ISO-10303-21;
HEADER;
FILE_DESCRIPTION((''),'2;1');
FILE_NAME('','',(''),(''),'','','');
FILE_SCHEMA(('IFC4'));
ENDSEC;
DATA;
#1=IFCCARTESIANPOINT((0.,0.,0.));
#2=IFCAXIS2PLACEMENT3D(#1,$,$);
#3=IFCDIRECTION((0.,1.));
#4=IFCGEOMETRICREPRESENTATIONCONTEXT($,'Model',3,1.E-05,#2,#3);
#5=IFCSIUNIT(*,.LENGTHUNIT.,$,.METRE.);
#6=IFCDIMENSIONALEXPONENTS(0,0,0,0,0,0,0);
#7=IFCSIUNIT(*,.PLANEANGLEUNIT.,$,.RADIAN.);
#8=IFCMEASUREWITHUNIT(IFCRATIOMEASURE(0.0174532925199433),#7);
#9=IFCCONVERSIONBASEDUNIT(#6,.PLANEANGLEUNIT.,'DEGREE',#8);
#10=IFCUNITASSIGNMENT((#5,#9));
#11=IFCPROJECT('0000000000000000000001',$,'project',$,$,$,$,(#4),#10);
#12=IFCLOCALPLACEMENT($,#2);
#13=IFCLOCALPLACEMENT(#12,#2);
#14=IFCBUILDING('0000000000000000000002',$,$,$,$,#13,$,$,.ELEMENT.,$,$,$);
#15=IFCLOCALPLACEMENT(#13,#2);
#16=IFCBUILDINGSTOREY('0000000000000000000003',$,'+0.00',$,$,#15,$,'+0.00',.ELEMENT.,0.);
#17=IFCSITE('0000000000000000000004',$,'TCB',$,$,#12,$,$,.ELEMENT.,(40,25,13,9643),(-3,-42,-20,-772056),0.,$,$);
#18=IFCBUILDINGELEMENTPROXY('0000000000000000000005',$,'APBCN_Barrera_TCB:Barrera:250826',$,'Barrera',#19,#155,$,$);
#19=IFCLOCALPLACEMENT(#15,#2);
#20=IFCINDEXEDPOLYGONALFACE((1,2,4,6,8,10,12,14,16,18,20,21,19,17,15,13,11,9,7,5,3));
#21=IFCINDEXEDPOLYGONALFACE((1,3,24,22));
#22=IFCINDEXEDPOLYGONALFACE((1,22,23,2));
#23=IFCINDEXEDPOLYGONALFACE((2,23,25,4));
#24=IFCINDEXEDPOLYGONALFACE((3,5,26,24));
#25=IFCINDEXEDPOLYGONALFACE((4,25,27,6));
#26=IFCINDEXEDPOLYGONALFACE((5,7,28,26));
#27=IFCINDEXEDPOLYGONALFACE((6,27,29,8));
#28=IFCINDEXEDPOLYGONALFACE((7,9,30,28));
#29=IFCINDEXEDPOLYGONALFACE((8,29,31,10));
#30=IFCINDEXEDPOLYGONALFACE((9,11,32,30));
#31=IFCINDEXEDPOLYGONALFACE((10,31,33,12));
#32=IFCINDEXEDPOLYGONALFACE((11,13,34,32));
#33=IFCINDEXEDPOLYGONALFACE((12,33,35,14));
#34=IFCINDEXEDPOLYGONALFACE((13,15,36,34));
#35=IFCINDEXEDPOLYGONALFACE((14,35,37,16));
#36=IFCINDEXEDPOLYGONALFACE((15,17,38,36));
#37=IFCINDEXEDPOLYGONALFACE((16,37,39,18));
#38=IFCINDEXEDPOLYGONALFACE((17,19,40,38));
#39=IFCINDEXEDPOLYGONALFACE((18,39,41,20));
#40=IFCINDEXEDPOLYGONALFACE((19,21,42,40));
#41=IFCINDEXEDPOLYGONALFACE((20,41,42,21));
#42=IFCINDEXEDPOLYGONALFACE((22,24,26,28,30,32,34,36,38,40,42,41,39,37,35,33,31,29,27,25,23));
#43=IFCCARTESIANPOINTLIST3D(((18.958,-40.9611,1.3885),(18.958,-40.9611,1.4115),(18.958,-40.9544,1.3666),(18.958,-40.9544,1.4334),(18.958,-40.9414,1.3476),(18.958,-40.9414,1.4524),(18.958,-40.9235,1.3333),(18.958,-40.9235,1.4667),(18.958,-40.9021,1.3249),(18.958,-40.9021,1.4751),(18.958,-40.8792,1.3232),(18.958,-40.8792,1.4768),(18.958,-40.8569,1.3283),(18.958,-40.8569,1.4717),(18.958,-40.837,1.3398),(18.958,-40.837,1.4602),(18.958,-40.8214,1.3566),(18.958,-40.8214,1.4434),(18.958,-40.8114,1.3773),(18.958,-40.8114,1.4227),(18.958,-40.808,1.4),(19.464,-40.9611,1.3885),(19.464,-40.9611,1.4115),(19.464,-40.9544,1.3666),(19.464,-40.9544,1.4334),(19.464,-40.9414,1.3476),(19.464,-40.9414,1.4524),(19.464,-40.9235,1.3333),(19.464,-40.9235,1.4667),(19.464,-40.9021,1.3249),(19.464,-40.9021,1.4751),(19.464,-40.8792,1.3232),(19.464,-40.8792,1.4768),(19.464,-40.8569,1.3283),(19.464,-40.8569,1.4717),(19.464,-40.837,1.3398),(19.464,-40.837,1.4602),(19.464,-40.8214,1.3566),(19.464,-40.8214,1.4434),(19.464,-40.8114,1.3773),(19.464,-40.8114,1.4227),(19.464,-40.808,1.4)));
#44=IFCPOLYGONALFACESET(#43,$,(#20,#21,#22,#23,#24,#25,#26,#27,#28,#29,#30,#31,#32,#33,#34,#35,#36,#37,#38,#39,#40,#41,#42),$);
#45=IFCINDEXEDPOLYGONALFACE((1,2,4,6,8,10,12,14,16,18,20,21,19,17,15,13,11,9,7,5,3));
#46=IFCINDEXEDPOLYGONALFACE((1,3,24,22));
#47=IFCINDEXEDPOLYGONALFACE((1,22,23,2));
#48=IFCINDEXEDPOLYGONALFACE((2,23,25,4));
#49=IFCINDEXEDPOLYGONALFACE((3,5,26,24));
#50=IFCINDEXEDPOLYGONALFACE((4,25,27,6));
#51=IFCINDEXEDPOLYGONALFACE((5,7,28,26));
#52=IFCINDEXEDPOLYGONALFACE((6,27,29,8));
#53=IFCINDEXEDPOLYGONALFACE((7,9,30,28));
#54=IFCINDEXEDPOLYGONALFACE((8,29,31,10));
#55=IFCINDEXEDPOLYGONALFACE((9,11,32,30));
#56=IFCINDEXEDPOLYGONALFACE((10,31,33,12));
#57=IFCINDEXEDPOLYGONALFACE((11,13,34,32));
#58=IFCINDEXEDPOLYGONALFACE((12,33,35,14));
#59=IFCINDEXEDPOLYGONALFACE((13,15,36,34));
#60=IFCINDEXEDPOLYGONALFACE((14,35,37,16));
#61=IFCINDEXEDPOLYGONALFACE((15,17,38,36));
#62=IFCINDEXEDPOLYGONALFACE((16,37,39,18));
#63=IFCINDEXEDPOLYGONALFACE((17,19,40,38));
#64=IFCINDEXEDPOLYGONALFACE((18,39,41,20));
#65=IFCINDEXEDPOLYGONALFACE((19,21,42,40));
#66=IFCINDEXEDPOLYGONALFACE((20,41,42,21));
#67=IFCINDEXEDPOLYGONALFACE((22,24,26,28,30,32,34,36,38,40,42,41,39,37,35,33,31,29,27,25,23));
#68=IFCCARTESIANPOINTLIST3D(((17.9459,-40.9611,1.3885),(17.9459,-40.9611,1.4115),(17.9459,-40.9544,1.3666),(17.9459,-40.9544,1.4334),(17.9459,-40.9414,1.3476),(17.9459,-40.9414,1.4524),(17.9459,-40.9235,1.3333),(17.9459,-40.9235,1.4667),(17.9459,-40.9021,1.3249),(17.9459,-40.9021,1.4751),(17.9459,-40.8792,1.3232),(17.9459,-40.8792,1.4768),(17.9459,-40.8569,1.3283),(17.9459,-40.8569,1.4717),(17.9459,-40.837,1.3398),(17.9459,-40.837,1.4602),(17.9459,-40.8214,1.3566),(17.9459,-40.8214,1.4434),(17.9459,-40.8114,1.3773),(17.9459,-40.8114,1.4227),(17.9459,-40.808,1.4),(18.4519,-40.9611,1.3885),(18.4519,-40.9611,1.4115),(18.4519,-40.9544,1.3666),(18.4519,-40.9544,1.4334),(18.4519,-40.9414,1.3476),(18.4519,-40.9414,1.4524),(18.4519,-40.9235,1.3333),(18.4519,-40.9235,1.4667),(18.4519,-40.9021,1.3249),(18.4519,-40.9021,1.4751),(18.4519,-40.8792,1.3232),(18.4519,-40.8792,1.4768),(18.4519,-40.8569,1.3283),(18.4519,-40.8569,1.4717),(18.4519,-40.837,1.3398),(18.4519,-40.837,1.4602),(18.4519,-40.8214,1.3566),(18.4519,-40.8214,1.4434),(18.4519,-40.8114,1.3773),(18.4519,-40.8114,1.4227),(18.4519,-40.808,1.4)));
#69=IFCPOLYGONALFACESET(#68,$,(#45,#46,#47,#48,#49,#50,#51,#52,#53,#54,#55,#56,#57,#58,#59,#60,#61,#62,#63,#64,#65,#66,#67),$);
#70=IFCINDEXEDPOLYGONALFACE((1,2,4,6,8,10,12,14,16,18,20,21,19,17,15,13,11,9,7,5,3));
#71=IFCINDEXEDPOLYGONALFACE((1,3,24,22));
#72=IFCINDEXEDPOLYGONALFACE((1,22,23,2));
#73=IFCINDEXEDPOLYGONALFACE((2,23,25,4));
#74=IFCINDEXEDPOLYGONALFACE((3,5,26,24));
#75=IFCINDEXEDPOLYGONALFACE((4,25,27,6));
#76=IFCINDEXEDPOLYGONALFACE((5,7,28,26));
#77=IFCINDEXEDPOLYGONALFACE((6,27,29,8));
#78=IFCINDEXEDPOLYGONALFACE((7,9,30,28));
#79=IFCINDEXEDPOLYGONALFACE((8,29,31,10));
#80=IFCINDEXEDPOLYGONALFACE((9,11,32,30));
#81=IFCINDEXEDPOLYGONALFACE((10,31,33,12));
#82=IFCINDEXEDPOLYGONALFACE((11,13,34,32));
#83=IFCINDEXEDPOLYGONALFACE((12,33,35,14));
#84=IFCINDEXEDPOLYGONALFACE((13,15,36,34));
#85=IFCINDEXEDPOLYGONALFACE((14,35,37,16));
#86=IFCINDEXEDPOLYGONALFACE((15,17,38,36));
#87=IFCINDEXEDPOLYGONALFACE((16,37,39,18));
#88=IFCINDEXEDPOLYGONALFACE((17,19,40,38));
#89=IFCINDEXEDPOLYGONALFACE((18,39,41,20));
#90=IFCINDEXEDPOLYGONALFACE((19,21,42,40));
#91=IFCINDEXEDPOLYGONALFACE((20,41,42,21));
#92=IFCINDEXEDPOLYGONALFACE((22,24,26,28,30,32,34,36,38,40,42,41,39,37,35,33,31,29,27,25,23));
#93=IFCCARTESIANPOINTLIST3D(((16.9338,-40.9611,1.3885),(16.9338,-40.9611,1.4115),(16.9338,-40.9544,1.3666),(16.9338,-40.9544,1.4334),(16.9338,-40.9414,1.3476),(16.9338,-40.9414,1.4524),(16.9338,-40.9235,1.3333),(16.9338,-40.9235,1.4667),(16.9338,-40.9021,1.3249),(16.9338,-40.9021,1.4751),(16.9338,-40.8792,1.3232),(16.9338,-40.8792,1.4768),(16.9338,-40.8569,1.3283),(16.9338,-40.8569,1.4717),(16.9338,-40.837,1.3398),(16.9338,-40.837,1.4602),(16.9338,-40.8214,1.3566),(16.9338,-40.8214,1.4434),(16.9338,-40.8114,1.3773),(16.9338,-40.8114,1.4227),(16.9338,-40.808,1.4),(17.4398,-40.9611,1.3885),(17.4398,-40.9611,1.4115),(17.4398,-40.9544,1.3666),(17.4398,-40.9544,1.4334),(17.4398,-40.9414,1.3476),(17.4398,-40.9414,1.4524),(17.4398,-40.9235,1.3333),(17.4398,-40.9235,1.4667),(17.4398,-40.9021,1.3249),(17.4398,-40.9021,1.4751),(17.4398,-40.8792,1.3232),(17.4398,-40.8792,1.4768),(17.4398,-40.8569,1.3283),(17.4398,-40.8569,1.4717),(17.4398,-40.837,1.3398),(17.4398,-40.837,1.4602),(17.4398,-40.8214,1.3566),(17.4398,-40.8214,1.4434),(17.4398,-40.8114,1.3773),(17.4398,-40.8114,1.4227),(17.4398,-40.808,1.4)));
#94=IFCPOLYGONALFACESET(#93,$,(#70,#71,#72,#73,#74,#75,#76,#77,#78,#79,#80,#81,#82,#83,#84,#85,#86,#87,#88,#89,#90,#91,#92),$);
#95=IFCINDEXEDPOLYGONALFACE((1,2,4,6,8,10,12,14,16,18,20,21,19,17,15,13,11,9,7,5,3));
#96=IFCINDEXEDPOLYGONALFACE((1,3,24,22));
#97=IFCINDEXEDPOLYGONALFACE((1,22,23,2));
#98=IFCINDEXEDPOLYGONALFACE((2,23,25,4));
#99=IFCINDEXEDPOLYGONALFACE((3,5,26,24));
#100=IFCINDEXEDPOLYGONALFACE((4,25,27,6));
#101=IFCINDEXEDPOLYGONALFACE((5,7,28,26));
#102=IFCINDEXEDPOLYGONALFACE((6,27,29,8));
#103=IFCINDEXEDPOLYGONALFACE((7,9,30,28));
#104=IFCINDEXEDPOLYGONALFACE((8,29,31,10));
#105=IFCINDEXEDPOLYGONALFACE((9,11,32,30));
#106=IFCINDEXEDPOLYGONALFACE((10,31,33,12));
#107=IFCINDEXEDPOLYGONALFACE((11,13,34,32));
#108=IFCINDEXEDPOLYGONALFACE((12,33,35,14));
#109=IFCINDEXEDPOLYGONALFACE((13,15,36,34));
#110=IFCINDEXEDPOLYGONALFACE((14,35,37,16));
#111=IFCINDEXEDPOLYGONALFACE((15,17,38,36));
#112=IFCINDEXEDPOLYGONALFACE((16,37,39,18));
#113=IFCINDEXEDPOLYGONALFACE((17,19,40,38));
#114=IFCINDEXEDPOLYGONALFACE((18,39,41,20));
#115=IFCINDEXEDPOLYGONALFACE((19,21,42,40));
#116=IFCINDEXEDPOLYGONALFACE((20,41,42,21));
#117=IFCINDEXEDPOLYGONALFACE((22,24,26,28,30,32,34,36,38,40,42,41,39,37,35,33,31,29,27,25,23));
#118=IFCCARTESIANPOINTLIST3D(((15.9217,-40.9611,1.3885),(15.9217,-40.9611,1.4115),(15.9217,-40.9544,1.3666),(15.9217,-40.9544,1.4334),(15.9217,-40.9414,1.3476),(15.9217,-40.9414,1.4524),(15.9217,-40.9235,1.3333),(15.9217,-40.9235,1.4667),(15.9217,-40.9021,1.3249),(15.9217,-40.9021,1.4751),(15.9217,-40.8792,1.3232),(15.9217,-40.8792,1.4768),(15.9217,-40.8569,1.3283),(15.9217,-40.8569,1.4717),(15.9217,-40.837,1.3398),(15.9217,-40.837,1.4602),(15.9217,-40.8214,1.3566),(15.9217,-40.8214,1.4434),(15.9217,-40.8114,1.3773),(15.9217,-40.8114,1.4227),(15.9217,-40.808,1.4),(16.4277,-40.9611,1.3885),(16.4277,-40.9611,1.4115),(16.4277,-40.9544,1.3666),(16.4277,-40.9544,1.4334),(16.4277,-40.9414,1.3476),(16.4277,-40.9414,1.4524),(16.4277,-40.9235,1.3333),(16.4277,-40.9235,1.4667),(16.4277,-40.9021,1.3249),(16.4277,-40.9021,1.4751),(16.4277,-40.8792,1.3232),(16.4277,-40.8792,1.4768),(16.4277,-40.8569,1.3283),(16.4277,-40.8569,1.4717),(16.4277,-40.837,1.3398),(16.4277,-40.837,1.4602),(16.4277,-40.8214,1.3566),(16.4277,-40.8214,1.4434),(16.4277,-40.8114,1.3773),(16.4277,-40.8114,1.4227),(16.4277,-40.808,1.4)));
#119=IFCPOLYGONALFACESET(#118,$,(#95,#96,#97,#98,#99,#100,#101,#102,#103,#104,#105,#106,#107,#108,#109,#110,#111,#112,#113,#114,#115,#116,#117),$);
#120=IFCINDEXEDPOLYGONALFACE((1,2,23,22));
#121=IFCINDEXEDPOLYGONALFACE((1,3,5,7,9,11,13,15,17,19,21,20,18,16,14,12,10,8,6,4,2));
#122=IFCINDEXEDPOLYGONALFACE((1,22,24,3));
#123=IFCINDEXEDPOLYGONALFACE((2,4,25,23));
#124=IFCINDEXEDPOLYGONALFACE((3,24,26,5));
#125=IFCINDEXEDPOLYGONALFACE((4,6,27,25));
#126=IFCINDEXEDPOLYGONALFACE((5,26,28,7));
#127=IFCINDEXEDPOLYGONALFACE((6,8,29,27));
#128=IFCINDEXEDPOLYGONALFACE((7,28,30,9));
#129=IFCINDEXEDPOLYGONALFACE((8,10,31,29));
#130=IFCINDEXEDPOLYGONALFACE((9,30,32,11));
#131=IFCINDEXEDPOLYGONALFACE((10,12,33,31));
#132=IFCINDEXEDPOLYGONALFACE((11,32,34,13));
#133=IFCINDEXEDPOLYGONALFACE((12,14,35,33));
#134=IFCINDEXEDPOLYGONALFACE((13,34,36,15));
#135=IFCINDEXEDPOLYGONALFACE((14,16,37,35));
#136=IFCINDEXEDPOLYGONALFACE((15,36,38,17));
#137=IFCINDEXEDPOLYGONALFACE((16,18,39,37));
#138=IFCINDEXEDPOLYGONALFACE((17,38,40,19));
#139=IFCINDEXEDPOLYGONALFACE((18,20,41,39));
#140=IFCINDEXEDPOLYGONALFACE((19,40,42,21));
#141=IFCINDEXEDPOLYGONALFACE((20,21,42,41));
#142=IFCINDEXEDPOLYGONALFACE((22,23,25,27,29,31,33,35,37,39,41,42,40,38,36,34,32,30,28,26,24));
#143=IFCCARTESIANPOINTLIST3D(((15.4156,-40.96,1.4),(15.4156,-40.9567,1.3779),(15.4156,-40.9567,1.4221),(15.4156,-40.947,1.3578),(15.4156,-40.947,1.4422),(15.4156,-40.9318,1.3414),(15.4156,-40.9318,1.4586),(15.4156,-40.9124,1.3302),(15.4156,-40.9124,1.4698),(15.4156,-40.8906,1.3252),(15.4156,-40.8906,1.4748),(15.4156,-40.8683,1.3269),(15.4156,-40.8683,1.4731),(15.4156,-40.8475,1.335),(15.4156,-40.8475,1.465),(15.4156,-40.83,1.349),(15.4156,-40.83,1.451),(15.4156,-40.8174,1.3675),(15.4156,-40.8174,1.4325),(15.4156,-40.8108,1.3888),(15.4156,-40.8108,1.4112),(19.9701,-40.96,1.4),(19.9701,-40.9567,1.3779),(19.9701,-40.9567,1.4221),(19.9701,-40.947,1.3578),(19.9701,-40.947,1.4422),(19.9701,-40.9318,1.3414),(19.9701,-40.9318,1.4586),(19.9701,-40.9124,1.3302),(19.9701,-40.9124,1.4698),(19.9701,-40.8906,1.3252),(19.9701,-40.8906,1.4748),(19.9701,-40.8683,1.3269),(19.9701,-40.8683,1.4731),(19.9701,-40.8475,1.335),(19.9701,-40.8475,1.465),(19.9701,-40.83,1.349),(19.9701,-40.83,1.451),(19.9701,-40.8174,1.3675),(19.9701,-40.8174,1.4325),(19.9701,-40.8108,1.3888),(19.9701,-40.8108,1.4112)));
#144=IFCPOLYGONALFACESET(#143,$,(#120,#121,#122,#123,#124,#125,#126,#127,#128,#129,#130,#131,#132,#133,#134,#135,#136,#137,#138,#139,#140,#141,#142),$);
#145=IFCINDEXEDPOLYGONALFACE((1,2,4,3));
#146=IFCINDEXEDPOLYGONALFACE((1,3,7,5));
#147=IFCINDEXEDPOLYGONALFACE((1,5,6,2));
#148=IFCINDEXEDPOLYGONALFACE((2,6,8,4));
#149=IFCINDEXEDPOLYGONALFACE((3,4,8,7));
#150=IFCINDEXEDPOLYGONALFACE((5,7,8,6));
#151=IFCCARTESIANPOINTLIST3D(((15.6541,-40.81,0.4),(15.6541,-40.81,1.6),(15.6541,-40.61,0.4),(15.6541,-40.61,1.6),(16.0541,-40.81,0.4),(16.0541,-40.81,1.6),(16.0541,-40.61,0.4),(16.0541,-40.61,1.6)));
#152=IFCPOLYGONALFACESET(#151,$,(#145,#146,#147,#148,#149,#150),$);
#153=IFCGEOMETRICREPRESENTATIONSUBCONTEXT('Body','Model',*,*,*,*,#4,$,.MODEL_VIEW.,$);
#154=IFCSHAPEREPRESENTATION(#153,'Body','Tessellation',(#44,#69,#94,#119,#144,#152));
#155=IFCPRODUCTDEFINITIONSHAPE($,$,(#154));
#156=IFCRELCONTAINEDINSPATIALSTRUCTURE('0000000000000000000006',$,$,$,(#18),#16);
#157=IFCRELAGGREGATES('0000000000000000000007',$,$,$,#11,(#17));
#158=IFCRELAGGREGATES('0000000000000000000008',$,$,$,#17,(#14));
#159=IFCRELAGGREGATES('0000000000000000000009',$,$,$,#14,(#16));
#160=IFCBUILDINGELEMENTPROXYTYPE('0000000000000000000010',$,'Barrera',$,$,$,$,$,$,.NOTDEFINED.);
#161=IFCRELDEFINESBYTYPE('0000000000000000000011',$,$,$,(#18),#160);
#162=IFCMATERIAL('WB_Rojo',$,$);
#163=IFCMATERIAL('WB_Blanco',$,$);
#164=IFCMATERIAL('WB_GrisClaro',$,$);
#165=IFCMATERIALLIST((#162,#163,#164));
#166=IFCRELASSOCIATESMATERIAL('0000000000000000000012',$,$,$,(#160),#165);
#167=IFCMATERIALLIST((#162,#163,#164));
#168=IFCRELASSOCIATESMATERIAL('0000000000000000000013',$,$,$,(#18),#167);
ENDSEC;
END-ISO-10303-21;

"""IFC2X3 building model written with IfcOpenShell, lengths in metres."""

from ifc_helpers import new_model, entity, si_unit, converted_unit, direction, frame, frame_2d, origin, place, context, subcontext, project, spatial, rectangle, circle, extrude, source, transform, mapped, material, material_list, type_object, type_shapes, element, save


model = new_model("IFC2X3")

# Units and contexts
model_context = context("Model", 3, precision=1e-05, world=origin(), true_north=direction((0.0, 1.0)))
body_context = subcontext(model_context, "Body", "Model", "MODEL_VIEW")
ifc_project = project(units=[si_unit("LENGTHUNIT", "METRE"), converted_unit("PLANEANGLEUNIT", "DEGREE", entity("IfcRatioMeasure", 0.0174532925199433), si_unit("PLANEANGLEUNIT", "RADIAN"), dimensions=[0, 0, 0, 0, 0, 0, 0])], contexts=[model_context])

# Site, building, storey
site_placement = place(None, origin())
site = spatial("IfcSite", under=ifc_project, at=site_placement, Name="TCB", CompositionType="ELEMENT", RefLatitude=(40, 25, 13, 9643), RefLongitude=(-3, -42, -20, -772056), RefElevation=0.0)
building_placement = place(site_placement, origin())
building = spatial("IfcBuilding", under=site, at=building_placement, CompositionType="ELEMENT")
storey_placement = place(building_placement, origin())
storey = spatial("IfcBuildingStorey", under=building, at=storey_placement, Name="+0.00", LongName="+0.00", CompositionType="ELEMENT", Elevation=0.0)

# Shared definitions
ifc_material_1 = material(Name="WB_Blanco")

# Shared definitions
ifc_material_2 = material(Name="WB_GrisClaro")

# Building element proxy
ifc_material_3 = material(Name="WB_Rojo")
ifc_material_list_1 = material_list([ifc_material_3, ifc_material_1, ifc_material_2])
building_element_proxy_type_1 = type_object("IfcBuildingElementProxyType", Name="Barrera", PredefinedType="NOTDEFINED", material=ifc_material_list_1)
shared_shape_1 = source(origin(), body_context, "Body", "SweptSolid", [
    extrude(circle(Radius=0.077, at=frame_2d((0.0, 0.0), x_axis=(1.0, 0.0))), frame((2.8039, -0.175, 1.0), z_axis=(1.0, 0.0, 0.0), x_axis=(0.0, 1.0, 0.0)), (0.0, 0.0, 1.0), 0.506),
    extrude(circle(Radius=0.077, at=frame_2d((0.0, 0.0), x_axis=(1.0, 0.0))), frame((1.7918, -0.175, 1.0), z_axis=(1.0, 0.0, 0.0), x_axis=(0.0, 1.0, 0.0)), (0.0, 0.0, 1.0), 0.506),
    extrude(circle(Radius=0.077, at=frame_2d((0.0, 0.0), x_axis=(1.0, 0.0))), frame((0.7797, -0.175, 1.0), z_axis=(1.0, 0.0, 0.0), x_axis=(0.0, 1.0, 0.0)), (0.0, 0.0, 1.0), 0.506),
    extrude(circle(Radius=0.077, at=frame_2d((0.0, 0.0), x_axis=(1.0, 0.0))), frame((-0.2324, -0.175, 1.0), z_axis=(1.0, 0.0, 0.0), x_axis=(0.0, 1.0, 0.0)), (0.0, 0.0, 1.0), 0.506),
    extrude(circle(Radius=0.075, at=frame_2d((0.0, 0.0), x_axis=(1.0, 0.0))), frame((-0.7385, -0.175, 1.0), z_axis=(1.0, 0.0, 0.0), x_axis=(0.0, -1.0, 0.0)), (0.0, 0.0, 1.0), 4.5544),
    extrude(rectangle(XDim=0.2, YDim=0.4, at=frame_2d((0.0, 0.0), x_axis=(1.0, 0.0))), frame((-0.3, 0.0, 0.0), z_axis=(0.0, 0.0, 1.0), x_axis=(0.0, -1.0, 0.0)), (0.0, 0.0, 1.0), 1.2),
])
type_shapes(building_element_proxy_type_1, [shared_shape_1])
ifc_material_list_2 = material_list([ifc_material_3, ifc_material_1, ifc_material_2])
proxy_1_placement = place(storey_placement, frame((16.1541, -40.71, 0.4)))
element("IfcBuildingElementProxy", 1, at=proxy_1_placement, inside=storey, type_object=building_element_proxy_type_1, material=ifc_material_list_2, Name="APBCN_Barrera_TCB:Barrera:250826", ObjectType="Barrera", context=body_context, shape_type="MappedRepresentation", body=[
    mapped(shared_shape_1, transform((0.0, 0.0, 0.0), scale=1.0)),
])

save(model, "model.ifc")
